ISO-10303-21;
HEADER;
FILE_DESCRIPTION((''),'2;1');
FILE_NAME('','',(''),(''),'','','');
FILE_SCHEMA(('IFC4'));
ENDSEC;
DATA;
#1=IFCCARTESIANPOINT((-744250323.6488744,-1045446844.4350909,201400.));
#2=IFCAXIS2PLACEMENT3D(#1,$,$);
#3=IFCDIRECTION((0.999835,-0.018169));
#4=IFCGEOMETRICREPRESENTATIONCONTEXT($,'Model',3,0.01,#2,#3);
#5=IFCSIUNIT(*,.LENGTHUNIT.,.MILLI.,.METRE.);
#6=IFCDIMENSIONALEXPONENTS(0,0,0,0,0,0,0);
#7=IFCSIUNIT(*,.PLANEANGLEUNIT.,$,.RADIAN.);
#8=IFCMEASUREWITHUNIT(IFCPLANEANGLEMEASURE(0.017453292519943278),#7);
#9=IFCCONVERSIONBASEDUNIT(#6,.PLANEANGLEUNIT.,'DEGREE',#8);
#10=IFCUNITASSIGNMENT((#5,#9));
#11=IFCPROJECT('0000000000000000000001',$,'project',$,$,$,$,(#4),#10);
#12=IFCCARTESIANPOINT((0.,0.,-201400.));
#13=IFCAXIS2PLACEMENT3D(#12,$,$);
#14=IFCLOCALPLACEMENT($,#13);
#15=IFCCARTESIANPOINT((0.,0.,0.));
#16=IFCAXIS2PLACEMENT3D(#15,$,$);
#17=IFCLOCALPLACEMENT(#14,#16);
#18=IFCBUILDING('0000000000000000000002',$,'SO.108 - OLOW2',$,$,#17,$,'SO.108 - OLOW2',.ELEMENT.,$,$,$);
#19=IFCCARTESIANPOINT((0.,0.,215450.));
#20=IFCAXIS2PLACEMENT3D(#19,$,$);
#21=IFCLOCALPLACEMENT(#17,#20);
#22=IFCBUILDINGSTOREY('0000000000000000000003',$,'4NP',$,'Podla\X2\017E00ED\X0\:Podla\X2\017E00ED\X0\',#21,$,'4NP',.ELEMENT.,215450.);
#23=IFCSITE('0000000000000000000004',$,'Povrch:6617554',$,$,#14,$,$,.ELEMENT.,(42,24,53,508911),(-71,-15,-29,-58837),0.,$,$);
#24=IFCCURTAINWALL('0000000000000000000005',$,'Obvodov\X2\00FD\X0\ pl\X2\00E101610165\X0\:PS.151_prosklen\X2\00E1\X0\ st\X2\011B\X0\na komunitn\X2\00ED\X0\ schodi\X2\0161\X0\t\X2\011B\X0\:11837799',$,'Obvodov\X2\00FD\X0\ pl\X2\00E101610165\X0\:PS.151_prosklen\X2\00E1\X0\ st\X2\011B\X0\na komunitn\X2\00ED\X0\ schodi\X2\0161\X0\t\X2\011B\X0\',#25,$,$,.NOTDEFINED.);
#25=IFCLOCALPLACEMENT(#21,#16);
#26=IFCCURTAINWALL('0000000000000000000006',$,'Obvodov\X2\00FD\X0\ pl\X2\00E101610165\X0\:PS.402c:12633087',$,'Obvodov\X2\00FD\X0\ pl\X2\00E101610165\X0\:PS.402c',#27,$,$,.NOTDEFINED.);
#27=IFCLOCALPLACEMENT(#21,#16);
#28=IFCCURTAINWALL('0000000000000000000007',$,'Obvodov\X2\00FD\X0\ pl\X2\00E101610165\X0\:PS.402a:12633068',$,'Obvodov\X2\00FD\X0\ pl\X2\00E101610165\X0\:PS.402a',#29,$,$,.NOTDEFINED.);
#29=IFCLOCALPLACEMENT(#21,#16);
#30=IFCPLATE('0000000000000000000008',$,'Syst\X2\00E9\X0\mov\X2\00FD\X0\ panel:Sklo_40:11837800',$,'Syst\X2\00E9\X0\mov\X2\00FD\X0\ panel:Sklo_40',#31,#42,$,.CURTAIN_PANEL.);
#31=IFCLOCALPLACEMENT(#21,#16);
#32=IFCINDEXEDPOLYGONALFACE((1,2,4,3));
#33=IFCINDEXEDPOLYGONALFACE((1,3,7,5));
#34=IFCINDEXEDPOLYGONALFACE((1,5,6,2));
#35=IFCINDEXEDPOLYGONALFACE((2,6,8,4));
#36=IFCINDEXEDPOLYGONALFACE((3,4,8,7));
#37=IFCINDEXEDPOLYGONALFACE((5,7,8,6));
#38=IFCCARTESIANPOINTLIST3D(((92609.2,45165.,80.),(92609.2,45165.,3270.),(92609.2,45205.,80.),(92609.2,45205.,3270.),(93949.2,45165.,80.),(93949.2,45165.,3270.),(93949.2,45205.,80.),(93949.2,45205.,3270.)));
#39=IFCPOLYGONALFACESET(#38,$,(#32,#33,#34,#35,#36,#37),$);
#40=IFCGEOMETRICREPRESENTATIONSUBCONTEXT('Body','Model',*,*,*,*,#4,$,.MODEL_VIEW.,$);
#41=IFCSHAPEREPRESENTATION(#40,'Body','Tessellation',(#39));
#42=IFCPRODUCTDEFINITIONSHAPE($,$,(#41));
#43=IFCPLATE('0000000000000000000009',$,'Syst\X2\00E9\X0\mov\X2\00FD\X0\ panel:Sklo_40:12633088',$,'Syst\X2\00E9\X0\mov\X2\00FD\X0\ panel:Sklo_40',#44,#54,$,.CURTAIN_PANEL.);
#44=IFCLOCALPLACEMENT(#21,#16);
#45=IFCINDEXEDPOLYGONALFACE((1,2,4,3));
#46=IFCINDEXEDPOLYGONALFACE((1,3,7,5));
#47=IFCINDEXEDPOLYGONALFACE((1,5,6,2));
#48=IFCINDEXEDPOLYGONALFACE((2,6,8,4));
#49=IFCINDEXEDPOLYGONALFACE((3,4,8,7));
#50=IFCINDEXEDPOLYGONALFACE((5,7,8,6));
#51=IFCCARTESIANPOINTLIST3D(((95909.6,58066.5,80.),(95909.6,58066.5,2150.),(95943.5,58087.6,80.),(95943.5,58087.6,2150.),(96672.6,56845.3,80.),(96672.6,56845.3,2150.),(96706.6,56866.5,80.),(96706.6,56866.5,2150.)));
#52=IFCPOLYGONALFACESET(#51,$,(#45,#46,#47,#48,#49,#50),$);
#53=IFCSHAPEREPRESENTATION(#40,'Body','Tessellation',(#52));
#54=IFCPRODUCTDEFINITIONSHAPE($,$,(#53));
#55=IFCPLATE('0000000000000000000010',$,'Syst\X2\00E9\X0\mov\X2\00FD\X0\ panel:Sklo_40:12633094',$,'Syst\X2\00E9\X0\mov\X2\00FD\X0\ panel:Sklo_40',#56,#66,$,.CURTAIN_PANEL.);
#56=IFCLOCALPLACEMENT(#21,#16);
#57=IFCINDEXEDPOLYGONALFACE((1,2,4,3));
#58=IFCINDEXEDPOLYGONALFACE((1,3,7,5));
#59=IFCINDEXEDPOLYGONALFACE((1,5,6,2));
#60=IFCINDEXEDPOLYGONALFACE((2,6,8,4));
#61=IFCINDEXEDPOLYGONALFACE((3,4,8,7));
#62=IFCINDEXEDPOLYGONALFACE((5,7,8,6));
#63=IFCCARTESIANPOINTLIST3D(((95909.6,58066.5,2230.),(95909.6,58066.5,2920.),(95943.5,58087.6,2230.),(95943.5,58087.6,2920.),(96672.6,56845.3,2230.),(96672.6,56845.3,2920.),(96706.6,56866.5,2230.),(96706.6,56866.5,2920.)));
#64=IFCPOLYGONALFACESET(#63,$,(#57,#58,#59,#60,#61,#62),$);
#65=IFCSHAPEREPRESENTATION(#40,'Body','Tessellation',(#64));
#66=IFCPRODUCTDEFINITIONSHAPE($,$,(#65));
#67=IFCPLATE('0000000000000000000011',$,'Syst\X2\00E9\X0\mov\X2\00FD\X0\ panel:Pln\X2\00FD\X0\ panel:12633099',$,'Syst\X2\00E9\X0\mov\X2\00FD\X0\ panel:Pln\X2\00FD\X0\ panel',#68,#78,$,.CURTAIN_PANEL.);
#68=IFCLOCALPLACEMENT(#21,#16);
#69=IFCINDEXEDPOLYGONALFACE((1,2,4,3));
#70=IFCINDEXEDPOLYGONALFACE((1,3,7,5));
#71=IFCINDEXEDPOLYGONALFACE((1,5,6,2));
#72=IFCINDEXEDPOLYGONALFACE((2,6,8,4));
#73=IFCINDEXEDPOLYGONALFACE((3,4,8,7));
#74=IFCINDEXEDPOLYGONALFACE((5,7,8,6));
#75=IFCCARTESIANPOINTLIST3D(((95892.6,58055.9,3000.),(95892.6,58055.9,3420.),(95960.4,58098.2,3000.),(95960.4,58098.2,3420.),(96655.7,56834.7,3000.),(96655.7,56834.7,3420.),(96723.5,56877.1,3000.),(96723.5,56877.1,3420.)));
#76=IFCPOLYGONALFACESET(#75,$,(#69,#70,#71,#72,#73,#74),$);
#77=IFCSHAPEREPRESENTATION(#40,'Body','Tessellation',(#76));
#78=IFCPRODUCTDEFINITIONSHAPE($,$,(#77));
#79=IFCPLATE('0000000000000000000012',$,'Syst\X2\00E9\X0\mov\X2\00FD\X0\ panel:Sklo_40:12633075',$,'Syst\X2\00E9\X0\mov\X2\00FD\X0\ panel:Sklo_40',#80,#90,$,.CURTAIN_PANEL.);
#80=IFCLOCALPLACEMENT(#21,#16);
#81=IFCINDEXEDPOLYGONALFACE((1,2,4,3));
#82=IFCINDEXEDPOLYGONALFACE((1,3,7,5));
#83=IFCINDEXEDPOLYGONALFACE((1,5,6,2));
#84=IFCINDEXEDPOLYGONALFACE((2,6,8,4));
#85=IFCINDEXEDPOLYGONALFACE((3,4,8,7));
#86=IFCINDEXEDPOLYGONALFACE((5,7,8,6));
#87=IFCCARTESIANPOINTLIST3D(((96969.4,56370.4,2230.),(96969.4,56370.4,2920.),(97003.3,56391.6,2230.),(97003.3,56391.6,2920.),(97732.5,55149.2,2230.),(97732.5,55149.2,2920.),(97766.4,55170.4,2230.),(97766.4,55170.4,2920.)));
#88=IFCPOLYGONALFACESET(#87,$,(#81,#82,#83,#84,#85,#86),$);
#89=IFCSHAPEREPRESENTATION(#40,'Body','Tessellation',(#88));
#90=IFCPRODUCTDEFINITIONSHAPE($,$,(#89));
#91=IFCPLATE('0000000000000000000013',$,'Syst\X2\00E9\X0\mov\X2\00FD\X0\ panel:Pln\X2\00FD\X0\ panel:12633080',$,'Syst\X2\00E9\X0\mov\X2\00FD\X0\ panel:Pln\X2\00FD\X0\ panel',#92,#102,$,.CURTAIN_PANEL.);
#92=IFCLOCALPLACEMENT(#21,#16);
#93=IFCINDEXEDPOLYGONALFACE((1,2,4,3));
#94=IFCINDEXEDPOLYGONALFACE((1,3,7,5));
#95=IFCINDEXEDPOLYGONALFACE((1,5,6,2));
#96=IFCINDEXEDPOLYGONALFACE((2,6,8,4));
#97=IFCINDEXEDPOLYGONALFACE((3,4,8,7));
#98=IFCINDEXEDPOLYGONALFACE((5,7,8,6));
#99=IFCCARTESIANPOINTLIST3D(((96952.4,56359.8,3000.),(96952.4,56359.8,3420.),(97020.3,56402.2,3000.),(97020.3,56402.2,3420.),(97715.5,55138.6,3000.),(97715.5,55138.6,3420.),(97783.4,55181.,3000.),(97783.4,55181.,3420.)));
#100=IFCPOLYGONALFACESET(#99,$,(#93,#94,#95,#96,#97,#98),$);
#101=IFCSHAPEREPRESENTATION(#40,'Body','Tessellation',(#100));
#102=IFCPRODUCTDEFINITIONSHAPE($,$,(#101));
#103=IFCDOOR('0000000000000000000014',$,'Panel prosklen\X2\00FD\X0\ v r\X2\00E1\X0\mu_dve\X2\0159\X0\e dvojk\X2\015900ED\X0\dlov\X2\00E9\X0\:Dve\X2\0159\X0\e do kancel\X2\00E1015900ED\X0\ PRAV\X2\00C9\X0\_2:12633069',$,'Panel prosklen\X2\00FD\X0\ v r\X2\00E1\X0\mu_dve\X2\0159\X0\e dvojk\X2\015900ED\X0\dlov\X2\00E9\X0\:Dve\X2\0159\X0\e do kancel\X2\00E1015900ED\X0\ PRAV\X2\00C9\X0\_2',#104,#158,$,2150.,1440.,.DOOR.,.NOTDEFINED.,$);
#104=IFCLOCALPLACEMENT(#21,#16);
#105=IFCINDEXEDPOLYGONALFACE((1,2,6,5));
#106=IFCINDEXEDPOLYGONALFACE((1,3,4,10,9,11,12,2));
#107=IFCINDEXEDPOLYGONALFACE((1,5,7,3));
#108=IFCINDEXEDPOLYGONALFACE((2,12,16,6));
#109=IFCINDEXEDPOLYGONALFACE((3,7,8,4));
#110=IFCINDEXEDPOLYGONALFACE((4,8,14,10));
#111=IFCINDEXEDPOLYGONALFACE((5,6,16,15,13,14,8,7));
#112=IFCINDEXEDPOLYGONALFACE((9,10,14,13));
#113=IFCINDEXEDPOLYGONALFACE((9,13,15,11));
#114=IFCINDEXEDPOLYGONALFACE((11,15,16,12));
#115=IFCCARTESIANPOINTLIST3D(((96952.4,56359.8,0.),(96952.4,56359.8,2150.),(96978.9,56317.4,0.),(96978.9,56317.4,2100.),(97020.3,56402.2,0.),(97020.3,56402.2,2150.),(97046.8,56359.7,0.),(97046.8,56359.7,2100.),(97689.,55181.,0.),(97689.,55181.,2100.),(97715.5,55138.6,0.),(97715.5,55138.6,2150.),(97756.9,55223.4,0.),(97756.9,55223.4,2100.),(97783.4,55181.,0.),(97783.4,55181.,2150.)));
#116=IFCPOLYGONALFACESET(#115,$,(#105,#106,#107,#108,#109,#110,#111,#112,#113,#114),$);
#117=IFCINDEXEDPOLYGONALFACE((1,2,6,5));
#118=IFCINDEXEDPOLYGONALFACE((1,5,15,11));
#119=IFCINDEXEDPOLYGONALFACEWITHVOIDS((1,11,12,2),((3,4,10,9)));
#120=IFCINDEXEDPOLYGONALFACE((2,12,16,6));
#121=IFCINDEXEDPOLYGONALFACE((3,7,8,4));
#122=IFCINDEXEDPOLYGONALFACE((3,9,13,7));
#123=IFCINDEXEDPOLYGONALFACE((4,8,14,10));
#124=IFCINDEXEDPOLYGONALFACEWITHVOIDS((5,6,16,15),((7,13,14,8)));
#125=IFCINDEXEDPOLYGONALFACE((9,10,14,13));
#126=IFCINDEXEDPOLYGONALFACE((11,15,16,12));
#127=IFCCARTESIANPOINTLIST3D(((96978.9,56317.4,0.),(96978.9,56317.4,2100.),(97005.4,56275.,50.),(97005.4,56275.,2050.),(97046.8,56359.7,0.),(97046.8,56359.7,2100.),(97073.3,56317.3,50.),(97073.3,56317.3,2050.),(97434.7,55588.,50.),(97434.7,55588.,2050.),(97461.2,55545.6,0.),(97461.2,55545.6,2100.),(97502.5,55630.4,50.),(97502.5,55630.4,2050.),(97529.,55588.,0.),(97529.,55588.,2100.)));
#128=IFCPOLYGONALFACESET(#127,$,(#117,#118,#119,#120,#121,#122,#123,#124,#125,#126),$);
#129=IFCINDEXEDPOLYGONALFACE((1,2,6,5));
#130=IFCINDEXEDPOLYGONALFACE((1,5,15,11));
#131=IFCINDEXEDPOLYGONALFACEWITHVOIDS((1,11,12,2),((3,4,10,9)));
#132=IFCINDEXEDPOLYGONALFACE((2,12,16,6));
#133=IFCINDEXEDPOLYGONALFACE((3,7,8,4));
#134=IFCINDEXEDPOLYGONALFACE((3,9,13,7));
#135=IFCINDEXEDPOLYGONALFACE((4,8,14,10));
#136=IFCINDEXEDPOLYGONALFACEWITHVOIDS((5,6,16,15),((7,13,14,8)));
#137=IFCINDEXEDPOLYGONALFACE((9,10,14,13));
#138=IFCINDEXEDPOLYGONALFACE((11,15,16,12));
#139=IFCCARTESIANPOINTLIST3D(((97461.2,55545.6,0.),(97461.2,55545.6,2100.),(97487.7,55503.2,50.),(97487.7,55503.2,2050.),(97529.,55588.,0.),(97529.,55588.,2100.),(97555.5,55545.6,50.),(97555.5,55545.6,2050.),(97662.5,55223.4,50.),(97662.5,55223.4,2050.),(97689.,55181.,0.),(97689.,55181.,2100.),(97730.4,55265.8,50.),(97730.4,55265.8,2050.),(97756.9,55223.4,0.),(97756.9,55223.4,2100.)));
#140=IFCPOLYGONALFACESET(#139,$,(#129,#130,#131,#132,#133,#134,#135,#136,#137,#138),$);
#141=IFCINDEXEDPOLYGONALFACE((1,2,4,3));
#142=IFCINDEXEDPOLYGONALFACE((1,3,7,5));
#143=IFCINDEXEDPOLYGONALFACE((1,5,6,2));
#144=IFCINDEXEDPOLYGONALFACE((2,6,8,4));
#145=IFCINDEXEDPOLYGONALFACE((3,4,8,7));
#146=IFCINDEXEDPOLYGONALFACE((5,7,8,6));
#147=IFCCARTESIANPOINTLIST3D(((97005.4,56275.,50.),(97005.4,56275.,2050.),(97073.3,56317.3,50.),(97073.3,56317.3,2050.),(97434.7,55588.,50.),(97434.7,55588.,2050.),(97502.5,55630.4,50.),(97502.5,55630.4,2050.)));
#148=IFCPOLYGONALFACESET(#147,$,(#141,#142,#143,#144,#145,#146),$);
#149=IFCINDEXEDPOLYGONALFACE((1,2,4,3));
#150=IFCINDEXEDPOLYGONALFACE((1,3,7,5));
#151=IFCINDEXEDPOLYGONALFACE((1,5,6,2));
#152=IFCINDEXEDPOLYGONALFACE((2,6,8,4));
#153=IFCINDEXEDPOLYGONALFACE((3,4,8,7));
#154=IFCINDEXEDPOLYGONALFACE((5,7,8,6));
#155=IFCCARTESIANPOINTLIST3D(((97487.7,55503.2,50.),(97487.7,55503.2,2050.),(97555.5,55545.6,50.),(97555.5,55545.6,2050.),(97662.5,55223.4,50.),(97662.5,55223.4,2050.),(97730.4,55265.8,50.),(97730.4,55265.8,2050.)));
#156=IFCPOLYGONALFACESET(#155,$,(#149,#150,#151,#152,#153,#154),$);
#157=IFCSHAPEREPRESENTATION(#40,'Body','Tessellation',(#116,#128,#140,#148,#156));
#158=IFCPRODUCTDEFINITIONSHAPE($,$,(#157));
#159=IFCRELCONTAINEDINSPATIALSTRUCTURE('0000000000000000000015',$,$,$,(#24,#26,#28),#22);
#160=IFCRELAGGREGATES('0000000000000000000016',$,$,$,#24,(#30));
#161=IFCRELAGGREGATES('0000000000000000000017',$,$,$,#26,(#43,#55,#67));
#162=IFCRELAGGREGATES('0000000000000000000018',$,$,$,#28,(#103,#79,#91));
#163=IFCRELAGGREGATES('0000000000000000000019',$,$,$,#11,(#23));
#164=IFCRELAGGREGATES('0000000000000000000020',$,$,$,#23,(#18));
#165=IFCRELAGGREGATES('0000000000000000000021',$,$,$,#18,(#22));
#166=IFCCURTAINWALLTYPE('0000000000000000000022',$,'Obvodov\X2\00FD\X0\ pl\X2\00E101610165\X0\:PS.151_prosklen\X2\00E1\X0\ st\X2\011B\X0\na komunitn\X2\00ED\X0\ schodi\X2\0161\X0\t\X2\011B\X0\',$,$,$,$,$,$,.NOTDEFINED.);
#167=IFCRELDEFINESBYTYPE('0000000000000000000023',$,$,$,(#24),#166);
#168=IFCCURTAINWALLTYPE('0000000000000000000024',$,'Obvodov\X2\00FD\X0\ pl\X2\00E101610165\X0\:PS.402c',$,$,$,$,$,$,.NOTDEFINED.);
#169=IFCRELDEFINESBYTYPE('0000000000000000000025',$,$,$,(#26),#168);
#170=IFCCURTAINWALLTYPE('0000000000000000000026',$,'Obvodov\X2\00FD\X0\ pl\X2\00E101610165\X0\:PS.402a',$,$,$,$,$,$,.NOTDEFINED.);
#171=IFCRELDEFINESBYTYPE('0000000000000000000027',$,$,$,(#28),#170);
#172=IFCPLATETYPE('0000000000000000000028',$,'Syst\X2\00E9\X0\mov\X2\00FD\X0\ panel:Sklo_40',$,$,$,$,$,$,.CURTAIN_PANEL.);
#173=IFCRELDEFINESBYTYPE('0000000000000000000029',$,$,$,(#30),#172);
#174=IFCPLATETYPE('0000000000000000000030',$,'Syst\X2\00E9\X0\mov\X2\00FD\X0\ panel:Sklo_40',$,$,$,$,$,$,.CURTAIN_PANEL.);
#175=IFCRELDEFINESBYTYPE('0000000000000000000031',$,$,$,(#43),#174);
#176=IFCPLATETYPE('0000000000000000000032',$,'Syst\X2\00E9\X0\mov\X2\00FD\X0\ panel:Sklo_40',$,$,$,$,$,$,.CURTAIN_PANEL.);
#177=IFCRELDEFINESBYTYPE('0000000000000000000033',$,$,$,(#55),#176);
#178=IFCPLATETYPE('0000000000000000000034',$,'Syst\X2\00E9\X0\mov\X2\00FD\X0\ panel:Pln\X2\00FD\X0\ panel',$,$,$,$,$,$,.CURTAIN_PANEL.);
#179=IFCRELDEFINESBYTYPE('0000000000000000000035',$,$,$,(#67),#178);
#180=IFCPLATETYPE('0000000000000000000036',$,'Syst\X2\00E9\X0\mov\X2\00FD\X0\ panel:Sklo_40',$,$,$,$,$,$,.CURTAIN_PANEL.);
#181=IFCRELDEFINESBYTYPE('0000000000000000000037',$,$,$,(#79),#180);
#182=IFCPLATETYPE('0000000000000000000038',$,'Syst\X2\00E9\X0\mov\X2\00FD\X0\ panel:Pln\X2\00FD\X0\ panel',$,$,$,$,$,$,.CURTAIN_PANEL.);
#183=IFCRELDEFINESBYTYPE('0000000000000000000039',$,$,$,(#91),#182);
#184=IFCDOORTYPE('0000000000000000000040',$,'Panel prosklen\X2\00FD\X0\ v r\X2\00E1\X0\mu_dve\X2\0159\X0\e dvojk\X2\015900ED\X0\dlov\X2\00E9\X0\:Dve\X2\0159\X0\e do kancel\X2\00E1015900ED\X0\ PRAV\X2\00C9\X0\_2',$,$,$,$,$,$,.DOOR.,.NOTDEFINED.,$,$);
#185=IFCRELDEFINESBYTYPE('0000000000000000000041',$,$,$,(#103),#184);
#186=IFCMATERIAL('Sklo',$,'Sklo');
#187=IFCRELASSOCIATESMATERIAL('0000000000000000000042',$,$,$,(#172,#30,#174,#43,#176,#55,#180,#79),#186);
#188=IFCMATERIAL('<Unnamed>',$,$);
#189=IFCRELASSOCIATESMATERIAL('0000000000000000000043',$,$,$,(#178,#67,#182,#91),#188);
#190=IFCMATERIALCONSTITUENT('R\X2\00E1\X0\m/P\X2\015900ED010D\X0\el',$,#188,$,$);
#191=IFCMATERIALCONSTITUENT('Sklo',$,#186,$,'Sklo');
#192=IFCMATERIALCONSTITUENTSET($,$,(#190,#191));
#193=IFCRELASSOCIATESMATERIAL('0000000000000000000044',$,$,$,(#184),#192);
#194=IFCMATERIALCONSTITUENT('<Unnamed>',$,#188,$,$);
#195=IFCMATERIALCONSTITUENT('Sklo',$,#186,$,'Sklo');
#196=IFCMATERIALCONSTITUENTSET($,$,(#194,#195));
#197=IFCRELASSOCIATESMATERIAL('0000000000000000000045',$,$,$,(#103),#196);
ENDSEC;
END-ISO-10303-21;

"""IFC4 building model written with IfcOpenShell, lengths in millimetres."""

from ifc_helpers import new_model, entity, si_unit, converted_unit, direction, frame, origin, place, context, subcontext, project, spatial, indexed_curve, outline, extrude, source, transform, mapped, material, constituent, constituent_set, type_object, type_shapes, element, aggregate, save


model = new_model("IFC4")

# Units and contexts
model_context = context("Model", 3, precision=0.01, world=frame((-744250323.6488744, -1045446844.4350909, 201400.0)), true_north=direction((0.999835, -0.018169)))
body_context = subcontext(model_context, "Body", "Model", "MODEL_VIEW")
ifc_project = project(units=[si_unit("LENGTHUNIT", "METRE", prefix="MILLI"), converted_unit("PLANEANGLEUNIT", "DEGREE", entity("IfcPlaneAngleMeasure", 0.017453292519943278), si_unit("PLANEANGLEUNIT", "RADIAN"), dimensions=[0, 0, 0, 0, 0, 0, 0])], contexts=[model_context])

# Site, building, storey
site_placement = place(None, frame((0.0, 0.0, -201400.0)))
site = spatial("IfcSite", under=ifc_project, at=site_placement, Name="Povrch:6617554", CompositionType="ELEMENT", RefLatitude=(42, 24, 53, 508911), RefLongitude=(-71, -15, -29, -58837), RefElevation=0.0)
building_placement = place(site_placement, origin())
building = spatial("IfcBuilding", under=site, at=building_placement, Name="SO.108 - OLOW2", LongName="SO.108 - OLOW2", CompositionType="ELEMENT")
storey_placement = place(building_placement, frame((0.0, 0.0, 215450.0)))
storey = spatial("IfcBuildingStorey", under=building, at=storey_placement, Name="4NP", ObjectType="Podlaží:Podlaží", LongName="4NP", CompositionType="ELEMENT", Elevation=215450.0)

# Curtain wall
curtain_wall_type_1 = type_object("IfcCurtainWallType", Name="Obvodový plášť:PS.151_prosklená stěna komunitní schodiště", PredefinedType="NOTDEFINED")
curtain_wall_1_placement = place(storey_placement, frame((0.0, 0.0, -215450.0)))
curtain_wall_1 = element("IfcCurtainWall", 1, at=curtain_wall_1_placement, inside=storey, type_object=curtain_wall_type_1, Name="Obvodový plášť:PS.151_prosklená stěna komunitní schodiště:11837799", ObjectType="Obvodový plášť:PS.151_prosklená stěna komunitní schodiště", PredefinedType="NOTDEFINED")
ifc_material_1 = material(Name="<Unnamed>")

# Curtain wall
curtain_wall_type_2 = type_object("IfcCurtainWallType", Name="Obvodový plášť:PS.402c", PredefinedType="NOTDEFINED")
curtain_wall_2_placement = place(storey_placement, frame((0.0, 0.0, -215450.0)))
curtain_wall_2 = element("IfcCurtainWall", 2, at=curtain_wall_2_placement, inside=storey, type_object=curtain_wall_type_2, Name="Obvodový plášť:PS.402c:12633087", ObjectType="Obvodový plášť:PS.402c", PredefinedType="NOTDEFINED")

# Curtain wall
curtain_wall_type_3 = type_object("IfcCurtainWallType", Name="Obvodový plášť:PS.402a", PredefinedType="NOTDEFINED")
curtain_wall_3_placement = place(storey_placement, frame((0.0, 0.0, -215450.0)))
curtain_wall_3 = element("IfcCurtainWall", 3, at=curtain_wall_3_placement, inside=storey, type_object=curtain_wall_type_3, Name="Obvodový plášť:PS.402a:12633068", ObjectType="Obvodový plášť:PS.402a", PredefinedType="NOTDEFINED")

# Plates
ifc_material_2 = material(Name="Sklo", Category="Sklo")
plate_type_1 = type_object("IfcPlateType", Name="Systémový panel:Sklo_40", PredefinedType="CURTAIN_PANEL", material=ifc_material_2)
shared_shape_1 = source(origin(), body_context, "Body", "SweptSolid", [
    extrude(outline(indexed_curve([(-20.0, -670.0), (20.0, -670.0), (20.0, 670.0), (-20.0, 670.0), (-20.0, -670.0)], self_intersect=False)), frame((0.0, 0.0, 0.0), z_axis=(0.0, 0.0, 1.0), x_axis=(0.0, 1.0, 0.0)), (0.0, 0.0, 1.0), 3190.0),
])
type_shapes(plate_type_1, [shared_shape_1])
plate_1_placement = place(curtain_wall_1_placement, frame((93279.2, 45185.0, 215530.0)))
plate_1 = element("IfcPlate", 4, at=plate_1_placement, type_object=plate_type_1, material=ifc_material_2, Name="Systémový panel:Sklo_40:11837800", ObjectType="Systémový panel:Sklo_40", PredefinedType="CURTAIN_PANEL", context=body_context, shape_type="MappedRepresentation", body=[
    mapped(shared_shape_1, transform((0.0, 0.0, 0.0), scale=1.0)),
])
aggregate(curtain_wall_1, [plate_1])
plate_type_2 = type_object("IfcPlateType", Name="Systémový panel:Sklo_40", PredefinedType="CURTAIN_PANEL", material=ifc_material_2)
shared_shape_2 = source(origin(), body_context, "Body", "SweptSolid", [
    extrude(outline(indexed_curve([(-20.0, -720.0), (20.0, -720.0), (20.0, 720.0), (-20.0, 720.0), (-20.0, -720.0)], self_intersect=False)), frame((0.0, 0.0, 0.0), z_axis=(0.0, 0.0, 1.0), x_axis=(0.0, 1.0, 0.0)), (0.0, 0.0, 1.0), 2070.0),
])
type_shapes(plate_type_2, [shared_shape_2])
plate_2_placement = place(curtain_wall_2_placement, frame((96308.1, 57466.5, 215530.0), z_axis=(0.0, 0.0, 1.0), x_axis=(-0.529919, 0.848048, 0.0)))
plate_2 = element("IfcPlate", 5, at=plate_2_placement, type_object=plate_type_2, material=ifc_material_2, Name="Systémový panel:Sklo_40:12633088", ObjectType="Systémový panel:Sklo_40", PredefinedType="CURTAIN_PANEL", context=body_context, shape_type="MappedRepresentation", body=[
    mapped(shared_shape_2, transform((0.0, 0.0, 0.0), scale=1.0)),
])
plate_type_3 = type_object("IfcPlateType", Name="Systémový panel:Sklo_40", PredefinedType="CURTAIN_PANEL", material=ifc_material_2)
shared_shape_3 = source(origin(), body_context, "Body", "SweptSolid", [
    extrude(outline(indexed_curve([(-20.0, -720.0), (20.0, -720.0), (20.0, 720.0), (-20.0, 720.0), (-20.0, -720.0)], self_intersect=False)), frame((0.0, 0.0, 0.0), z_axis=(0.0, 0.0, 1.0), x_axis=(0.0, 1.0, 0.0)), (0.0, 0.0, 1.0), 690.0),
])
type_shapes(plate_type_3, [shared_shape_3])
plate_3_placement = place(curtain_wall_2_placement, frame((96308.1, 57466.5, 217680.0), z_axis=(0.0, 0.0, 1.0), x_axis=(-0.529919, 0.848048, 0.0)))
plate_3 = element("IfcPlate", 6, at=plate_3_placement, type_object=plate_type_3, material=ifc_material_2, Name="Systémový panel:Sklo_40:12633094", ObjectType="Systémový panel:Sklo_40", PredefinedType="CURTAIN_PANEL", context=body_context, shape_type="MappedRepresentation", body=[
    mapped(shared_shape_3, transform((0.0, 0.0, 0.0), scale=1.0)),
])
plate_type_4 = type_object("IfcPlateType", Name="Systémový panel:Plný panel", PredefinedType="CURTAIN_PANEL", material=ifc_material_1)
shared_shape_4 = source(origin(), body_context, "Body", "SweptSolid", [
    extrude(outline(indexed_curve([(-40.0, -720.0), (40.0, -720.0), (40.0, 720.0), (-40.0, 720.0), (-40.0, -720.0)], self_intersect=False)), frame((0.0, 0.0, 0.0), z_axis=(0.0, 0.0, 1.0), x_axis=(0.0, 1.0, 0.0)), (0.0, 0.0, 1.0), 420.0),
])
type_shapes(plate_type_4, [shared_shape_4])
plate_4_placement = place(curtain_wall_2_placement, frame((96308.1, 57466.5, 218450.0), z_axis=(0.0, 0.0, 1.0), x_axis=(-0.529919, 0.848048, 0.0)))
plate_4 = element("IfcPlate", 7, at=plate_4_placement, type_object=plate_type_4, material=ifc_material_1, Name="Systémový panel:Plný panel:12633099", ObjectType="Systémový panel:Plný panel", PredefinedType="CURTAIN_PANEL", context=body_context, shape_type="MappedRepresentation", body=[
    mapped(shared_shape_4, transform((0.0, 0.0, 0.0), scale=1.0)),
])
aggregate(curtain_wall_2, [plate_2, plate_3, plate_4])
plate_type_5 = type_object("IfcPlateType", Name="Systémový panel:Sklo_40", PredefinedType="CURTAIN_PANEL", material=ifc_material_2)
shared_shape_5 = source(origin(), body_context, "Body", "SweptSolid", [
    extrude(outline(indexed_curve([(-20.0, -720.0), (20.0, -720.0), (20.0, 720.0), (-20.0, 720.0), (-20.0, -720.0)], self_intersect=False)), frame((0.0, 0.0, 0.0), z_axis=(0.0, 0.0, 1.0), x_axis=(0.0, 1.0, 0.0)), (0.0, 0.0, 1.0), 690.0),
])
type_shapes(plate_type_5, [shared_shape_5])
plate_5_placement = place(curtain_wall_3_placement, frame((97367.9, 55770.4, 217680.0), z_axis=(0.0, 0.0, 1.0), x_axis=(-0.529919, 0.848048, 0.0)))
plate_5 = element("IfcPlate", 8, at=plate_5_placement, type_object=plate_type_5, material=ifc_material_2, Name="Systémový panel:Sklo_40:12633075", ObjectType="Systémový panel:Sklo_40", PredefinedType="CURTAIN_PANEL", context=body_context, shape_type="MappedRepresentation", body=[
    mapped(shared_shape_5, transform((0.0, 0.0, 0.0), scale=1.0)),
])
plate_type_6 = type_object("IfcPlateType", Name="Systémový panel:Plný panel", PredefinedType="CURTAIN_PANEL", material=ifc_material_1)
shared_shape_6 = source(origin(), body_context, "Body", "SweptSolid", [
    extrude(outline(indexed_curve([(-40.0, -720.0), (40.0, -720.0), (40.0, 720.0), (-40.0, 720.0), (-40.0, -720.0)], self_intersect=False)), frame((0.0, 0.0, 0.0), z_axis=(0.0, 0.0, 1.0), x_axis=(0.0, 1.0, 0.0)), (0.0, 0.0, 1.0), 420.0),
])
type_shapes(plate_type_6, [shared_shape_6])
plate_6_placement = place(curtain_wall_3_placement, frame((97367.9, 55770.4, 218450.0), z_axis=(0.0, 0.0, 1.0), x_axis=(-0.529919, 0.848048, 0.0)))
plate_6 = element("IfcPlate", 9, at=plate_6_placement, type_object=plate_type_6, material=ifc_material_1, Name="Systémový panel:Plný panel:12633080", ObjectType="Systémový panel:Plný panel", PredefinedType="CURTAIN_PANEL", context=body_context, shape_type="MappedRepresentation", body=[
    mapped(shared_shape_6, transform((0.0, 0.0, 0.0), scale=1.0)),
])

# Door
ifc_constituent_1 = constituent(ifc_material_1, Name="<Unnamed>")
ifc_constituent_2 = constituent(ifc_material_2, Name="Sklo", Category="Sklo")
ifc_constituent_set_1 = constituent_set(constituents=[ifc_constituent_1, ifc_constituent_2])
ifc_constituent_3 = constituent(ifc_material_1, Name="Rám/Příčel")
ifc_constituent_4 = constituent(ifc_material_2, Name="Sklo", Category="Sklo")
ifc_constituent_set_2 = constituent_set(constituents=[ifc_constituent_3, ifc_constituent_4])
door_type = type_object("IfcDoorType", Name="Panel prosklený v rámu_dveře dvojkřídlové:Dveře do kanceláří PRAVÉ_2", OperationType="NOTDEFINED", PredefinedType="DOOR", material=ifc_constituent_set_2)
shared_shape_7 = source(origin(), body_context, "Body", "SweptSolid", [
    extrude(outline(indexed_curve([(-720.0, -1087.5), (720.0, -1087.5), (720.0, 1062.5), (670.0, 1062.5), (670.0, -1037.5), (-670.0, -1037.5), (-670.0, 1062.5), (-720.0, 1062.5), (-720.0, -1087.5)], self_intersect=False)), frame((0.0, -40.0, 1062.5), z_axis=(0.0, 1.0, 0.0), x_axis=(1.0, 0.0, 0.0)), (0.0, 0.0, 1.0), 80.0),
    extrude(outline(indexed_curve([(-1050.0, -455.0), (1050.0, -455.0), (1050.0, 455.0), (-1050.0, 455.0), (-1050.0, -455.0)], self_intersect=False), holes=[indexed_curve([(-1000.0, -405.0), (-1000.0, 405.0), (1000.0, 405.0), (1000.0, -405.0), (-1000.0, -405.0)], self_intersect=False)]), frame((215.0, -40.0, 1050.0), z_axis=(0.0, 1.0, 0.0), x_axis=(0.0, 0.0, -1.0)), (0.0, 0.0, 1.0), 80.0),
    extrude(outline(indexed_curve([(-1050.0, -215.0), (1050.0, -215.0), (1050.0, 215.0), (-1050.0, 215.0), (-1050.0, -215.0)], self_intersect=False), holes=[indexed_curve([(-1000.0, -165.0), (-1000.0, 165.0), (1000.0, 165.0), (1000.0, -165.0), (-1000.0, -165.0)], self_intersect=False)]), frame((-455.0, -40.0, 1050.0), z_axis=(0.0, 1.0, 0.0), x_axis=(0.0, 0.0, -1.0)), (0.0, 0.0, 1.0), 80.0),
    extrude(outline(indexed_curve([(-40.0, -405.0), (40.0, -405.0), (40.0, 405.0), (-40.0, 405.0), (-40.0, -405.0)], self_intersect=False)), frame((215.0, 0.0, 50.0), z_axis=(0.0, 0.0, 1.0), x_axis=(0.0, 1.0, 0.0)), (0.0, 0.0, 1.0), 2000.0),
    extrude(outline(indexed_curve([(-40.0, -165.0), (40.0, -165.0), (40.0, 165.0), (-40.0, 165.0), (-40.0, -165.0)], self_intersect=False)), frame((-455.0, 0.0, 50.0), z_axis=(0.0, 0.0, 1.0), x_axis=(0.0, 1.0, 0.0)), (0.0, 0.0, 1.0), 2000.0),
])
type_shapes(door_type, [shared_shape_7])
door_placement = place(curtain_wall_3_placement, frame((97367.9, 55770.4, 215450.0), z_axis=(0.0, 0.0, 1.0), x_axis=(-0.529919, 0.848048, 0.0)))
door = element("IfcDoor", 10, at=door_placement, type_object=door_type, material=ifc_constituent_set_1, Name="Panel prosklený v rámu_dveře dvojkřídlové:Dveře do kanceláří PRAVÉ_2:12633069", ObjectType="Panel prosklený v rámu_dveře dvojkřídlové:Dveře do kanceláří PRAVÉ_2", OperationType="NOTDEFINED", OverallHeight=2150.0, OverallWidth=1440.0, PredefinedType="DOOR", context=body_context, shape_type="MappedRepresentation", body=[
    mapped(shared_shape_7, transform((0.0, 0.0, 0.0), scale=1.0)),
])
aggregate(curtain_wall_3, [door, plate_5, plate_6])

save(model, "model.ifc")
